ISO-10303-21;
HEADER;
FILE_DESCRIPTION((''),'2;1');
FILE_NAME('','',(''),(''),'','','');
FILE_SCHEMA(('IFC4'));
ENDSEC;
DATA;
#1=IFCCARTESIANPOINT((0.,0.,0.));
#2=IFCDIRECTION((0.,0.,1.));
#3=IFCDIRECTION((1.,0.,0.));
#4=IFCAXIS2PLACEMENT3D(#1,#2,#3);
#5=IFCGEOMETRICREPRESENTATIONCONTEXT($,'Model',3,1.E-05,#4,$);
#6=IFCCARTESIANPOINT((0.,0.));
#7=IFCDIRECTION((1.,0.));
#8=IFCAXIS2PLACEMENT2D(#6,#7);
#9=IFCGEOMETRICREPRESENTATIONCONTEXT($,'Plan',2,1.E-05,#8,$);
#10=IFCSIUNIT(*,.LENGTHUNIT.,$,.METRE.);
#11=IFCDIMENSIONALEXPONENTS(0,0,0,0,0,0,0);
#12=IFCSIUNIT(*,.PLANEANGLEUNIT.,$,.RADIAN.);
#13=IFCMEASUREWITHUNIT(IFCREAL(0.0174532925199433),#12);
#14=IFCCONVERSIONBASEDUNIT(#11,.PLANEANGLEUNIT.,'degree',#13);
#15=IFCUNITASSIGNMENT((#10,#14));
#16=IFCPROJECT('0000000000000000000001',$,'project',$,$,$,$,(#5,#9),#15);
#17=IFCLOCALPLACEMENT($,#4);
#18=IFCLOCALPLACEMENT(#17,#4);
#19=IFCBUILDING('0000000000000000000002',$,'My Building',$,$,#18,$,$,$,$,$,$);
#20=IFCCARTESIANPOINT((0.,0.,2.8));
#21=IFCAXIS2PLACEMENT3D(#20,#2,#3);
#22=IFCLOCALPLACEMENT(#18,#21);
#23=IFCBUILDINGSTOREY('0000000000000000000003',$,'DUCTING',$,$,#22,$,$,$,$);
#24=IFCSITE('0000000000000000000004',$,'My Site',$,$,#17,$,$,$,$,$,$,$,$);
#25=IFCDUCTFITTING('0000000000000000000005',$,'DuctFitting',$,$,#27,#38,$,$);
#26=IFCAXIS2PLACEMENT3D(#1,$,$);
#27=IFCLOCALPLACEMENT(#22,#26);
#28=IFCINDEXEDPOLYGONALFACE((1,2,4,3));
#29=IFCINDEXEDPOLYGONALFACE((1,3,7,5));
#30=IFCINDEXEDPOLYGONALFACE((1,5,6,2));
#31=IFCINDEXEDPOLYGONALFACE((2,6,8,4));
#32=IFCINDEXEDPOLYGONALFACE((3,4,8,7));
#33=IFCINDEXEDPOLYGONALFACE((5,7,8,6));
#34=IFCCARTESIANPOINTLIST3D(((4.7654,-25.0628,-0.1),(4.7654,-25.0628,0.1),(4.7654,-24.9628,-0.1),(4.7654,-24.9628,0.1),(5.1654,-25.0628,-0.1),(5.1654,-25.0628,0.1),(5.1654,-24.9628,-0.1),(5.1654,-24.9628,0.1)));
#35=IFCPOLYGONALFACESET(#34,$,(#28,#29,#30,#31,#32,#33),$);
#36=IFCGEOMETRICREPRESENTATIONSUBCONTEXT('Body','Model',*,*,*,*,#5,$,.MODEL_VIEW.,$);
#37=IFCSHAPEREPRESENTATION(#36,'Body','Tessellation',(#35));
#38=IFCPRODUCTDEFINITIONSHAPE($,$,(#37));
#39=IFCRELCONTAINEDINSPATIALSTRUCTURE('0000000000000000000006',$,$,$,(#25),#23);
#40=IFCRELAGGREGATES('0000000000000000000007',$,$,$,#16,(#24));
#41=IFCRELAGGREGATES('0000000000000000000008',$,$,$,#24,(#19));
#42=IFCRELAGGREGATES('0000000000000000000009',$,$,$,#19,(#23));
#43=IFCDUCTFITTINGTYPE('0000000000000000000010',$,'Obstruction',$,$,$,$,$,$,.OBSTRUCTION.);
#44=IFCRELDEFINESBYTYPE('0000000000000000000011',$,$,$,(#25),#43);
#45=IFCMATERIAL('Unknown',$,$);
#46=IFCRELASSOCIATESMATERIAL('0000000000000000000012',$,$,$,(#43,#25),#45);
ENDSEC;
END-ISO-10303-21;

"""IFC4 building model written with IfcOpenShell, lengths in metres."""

from ifc_helpers import new_model, entity, si_unit, converted_unit, frame, origin_with_axes, origin_2d_with_axis, place, context, subcontext, project, spatial, rectangle, extrude, material, material_profile, profile_set, profile_usage, type_object, element, save


model = new_model("IFC4")

# Units and contexts
model_context = context("Model", 3, precision=1e-05, world=origin_with_axes())
plan_context = context("Plan", 2, precision=1e-05, world=origin_2d_with_axis())
body_context = subcontext(model_context, "Body", "Model", "MODEL_VIEW")
ifc_project = project(units=[si_unit("LENGTHUNIT", "METRE"), converted_unit("PLANEANGLEUNIT", "degree", entity("IfcReal", 0.0174532925199433), si_unit("PLANEANGLEUNIT", "RADIAN"), dimensions=[0, 0, 0, 0, 0, 0, 0])], contexts=[model_context, plan_context])

# Site, building, storey
site_placement = place(None, origin_with_axes())
site = spatial("IfcSite", under=ifc_project, at=site_placement, Name="My Site")
building_placement = place(site_placement, origin_with_axes())
building = spatial("IfcBuilding", under=site, at=building_placement, Name="My Building")
storey_placement = place(building_placement, frame((0.0, 0.0, 2.8), z_axis=(0.0, 0.0, 1.0), x_axis=(1.0, 0.0, 0.0)))
storey = spatial("IfcBuildingStorey", under=building, at=storey_placement, Name="DUCTING")

# Shared definitions
ifc_material = material(Name="Unknown")

# Duct fitting
ifc_material_profile_1 = material_profile(ifc_material, rectangle(XDim=0.4, YDim=0.2))
ifc_profile_set_1 = profile_set([ifc_material_profile_1])
duct_fitting_type_1 = type_object("IfcDuctFittingType", Name="Obstruction", PredefinedType="OBSTRUCTION", material=ifc_profile_set_1)
ifc_profile_usage_1 = profile_usage(ifc_profile_set_1, cardinal=5)
duct_fitting_1_placement = place(storey_placement, frame((4.9654, -24.9628, 0.0), z_axis=(0.0, -1.0, 0.0), x_axis=(1.0, 0.0, 0.0)))
element("IfcDuctFitting", 1, at=duct_fitting_1_placement, inside=storey, type_object=duct_fitting_type_1, material=ifc_profile_usage_1, Name="DuctFitting", context=body_context, shape_type="SweptSolid", body=[
    extrude(rectangle(XDim=0.4, YDim=0.2), origin_with_axes(), (0.0, 0.0, 1.0), 0.1),
])

save(model, "model.ifc")
